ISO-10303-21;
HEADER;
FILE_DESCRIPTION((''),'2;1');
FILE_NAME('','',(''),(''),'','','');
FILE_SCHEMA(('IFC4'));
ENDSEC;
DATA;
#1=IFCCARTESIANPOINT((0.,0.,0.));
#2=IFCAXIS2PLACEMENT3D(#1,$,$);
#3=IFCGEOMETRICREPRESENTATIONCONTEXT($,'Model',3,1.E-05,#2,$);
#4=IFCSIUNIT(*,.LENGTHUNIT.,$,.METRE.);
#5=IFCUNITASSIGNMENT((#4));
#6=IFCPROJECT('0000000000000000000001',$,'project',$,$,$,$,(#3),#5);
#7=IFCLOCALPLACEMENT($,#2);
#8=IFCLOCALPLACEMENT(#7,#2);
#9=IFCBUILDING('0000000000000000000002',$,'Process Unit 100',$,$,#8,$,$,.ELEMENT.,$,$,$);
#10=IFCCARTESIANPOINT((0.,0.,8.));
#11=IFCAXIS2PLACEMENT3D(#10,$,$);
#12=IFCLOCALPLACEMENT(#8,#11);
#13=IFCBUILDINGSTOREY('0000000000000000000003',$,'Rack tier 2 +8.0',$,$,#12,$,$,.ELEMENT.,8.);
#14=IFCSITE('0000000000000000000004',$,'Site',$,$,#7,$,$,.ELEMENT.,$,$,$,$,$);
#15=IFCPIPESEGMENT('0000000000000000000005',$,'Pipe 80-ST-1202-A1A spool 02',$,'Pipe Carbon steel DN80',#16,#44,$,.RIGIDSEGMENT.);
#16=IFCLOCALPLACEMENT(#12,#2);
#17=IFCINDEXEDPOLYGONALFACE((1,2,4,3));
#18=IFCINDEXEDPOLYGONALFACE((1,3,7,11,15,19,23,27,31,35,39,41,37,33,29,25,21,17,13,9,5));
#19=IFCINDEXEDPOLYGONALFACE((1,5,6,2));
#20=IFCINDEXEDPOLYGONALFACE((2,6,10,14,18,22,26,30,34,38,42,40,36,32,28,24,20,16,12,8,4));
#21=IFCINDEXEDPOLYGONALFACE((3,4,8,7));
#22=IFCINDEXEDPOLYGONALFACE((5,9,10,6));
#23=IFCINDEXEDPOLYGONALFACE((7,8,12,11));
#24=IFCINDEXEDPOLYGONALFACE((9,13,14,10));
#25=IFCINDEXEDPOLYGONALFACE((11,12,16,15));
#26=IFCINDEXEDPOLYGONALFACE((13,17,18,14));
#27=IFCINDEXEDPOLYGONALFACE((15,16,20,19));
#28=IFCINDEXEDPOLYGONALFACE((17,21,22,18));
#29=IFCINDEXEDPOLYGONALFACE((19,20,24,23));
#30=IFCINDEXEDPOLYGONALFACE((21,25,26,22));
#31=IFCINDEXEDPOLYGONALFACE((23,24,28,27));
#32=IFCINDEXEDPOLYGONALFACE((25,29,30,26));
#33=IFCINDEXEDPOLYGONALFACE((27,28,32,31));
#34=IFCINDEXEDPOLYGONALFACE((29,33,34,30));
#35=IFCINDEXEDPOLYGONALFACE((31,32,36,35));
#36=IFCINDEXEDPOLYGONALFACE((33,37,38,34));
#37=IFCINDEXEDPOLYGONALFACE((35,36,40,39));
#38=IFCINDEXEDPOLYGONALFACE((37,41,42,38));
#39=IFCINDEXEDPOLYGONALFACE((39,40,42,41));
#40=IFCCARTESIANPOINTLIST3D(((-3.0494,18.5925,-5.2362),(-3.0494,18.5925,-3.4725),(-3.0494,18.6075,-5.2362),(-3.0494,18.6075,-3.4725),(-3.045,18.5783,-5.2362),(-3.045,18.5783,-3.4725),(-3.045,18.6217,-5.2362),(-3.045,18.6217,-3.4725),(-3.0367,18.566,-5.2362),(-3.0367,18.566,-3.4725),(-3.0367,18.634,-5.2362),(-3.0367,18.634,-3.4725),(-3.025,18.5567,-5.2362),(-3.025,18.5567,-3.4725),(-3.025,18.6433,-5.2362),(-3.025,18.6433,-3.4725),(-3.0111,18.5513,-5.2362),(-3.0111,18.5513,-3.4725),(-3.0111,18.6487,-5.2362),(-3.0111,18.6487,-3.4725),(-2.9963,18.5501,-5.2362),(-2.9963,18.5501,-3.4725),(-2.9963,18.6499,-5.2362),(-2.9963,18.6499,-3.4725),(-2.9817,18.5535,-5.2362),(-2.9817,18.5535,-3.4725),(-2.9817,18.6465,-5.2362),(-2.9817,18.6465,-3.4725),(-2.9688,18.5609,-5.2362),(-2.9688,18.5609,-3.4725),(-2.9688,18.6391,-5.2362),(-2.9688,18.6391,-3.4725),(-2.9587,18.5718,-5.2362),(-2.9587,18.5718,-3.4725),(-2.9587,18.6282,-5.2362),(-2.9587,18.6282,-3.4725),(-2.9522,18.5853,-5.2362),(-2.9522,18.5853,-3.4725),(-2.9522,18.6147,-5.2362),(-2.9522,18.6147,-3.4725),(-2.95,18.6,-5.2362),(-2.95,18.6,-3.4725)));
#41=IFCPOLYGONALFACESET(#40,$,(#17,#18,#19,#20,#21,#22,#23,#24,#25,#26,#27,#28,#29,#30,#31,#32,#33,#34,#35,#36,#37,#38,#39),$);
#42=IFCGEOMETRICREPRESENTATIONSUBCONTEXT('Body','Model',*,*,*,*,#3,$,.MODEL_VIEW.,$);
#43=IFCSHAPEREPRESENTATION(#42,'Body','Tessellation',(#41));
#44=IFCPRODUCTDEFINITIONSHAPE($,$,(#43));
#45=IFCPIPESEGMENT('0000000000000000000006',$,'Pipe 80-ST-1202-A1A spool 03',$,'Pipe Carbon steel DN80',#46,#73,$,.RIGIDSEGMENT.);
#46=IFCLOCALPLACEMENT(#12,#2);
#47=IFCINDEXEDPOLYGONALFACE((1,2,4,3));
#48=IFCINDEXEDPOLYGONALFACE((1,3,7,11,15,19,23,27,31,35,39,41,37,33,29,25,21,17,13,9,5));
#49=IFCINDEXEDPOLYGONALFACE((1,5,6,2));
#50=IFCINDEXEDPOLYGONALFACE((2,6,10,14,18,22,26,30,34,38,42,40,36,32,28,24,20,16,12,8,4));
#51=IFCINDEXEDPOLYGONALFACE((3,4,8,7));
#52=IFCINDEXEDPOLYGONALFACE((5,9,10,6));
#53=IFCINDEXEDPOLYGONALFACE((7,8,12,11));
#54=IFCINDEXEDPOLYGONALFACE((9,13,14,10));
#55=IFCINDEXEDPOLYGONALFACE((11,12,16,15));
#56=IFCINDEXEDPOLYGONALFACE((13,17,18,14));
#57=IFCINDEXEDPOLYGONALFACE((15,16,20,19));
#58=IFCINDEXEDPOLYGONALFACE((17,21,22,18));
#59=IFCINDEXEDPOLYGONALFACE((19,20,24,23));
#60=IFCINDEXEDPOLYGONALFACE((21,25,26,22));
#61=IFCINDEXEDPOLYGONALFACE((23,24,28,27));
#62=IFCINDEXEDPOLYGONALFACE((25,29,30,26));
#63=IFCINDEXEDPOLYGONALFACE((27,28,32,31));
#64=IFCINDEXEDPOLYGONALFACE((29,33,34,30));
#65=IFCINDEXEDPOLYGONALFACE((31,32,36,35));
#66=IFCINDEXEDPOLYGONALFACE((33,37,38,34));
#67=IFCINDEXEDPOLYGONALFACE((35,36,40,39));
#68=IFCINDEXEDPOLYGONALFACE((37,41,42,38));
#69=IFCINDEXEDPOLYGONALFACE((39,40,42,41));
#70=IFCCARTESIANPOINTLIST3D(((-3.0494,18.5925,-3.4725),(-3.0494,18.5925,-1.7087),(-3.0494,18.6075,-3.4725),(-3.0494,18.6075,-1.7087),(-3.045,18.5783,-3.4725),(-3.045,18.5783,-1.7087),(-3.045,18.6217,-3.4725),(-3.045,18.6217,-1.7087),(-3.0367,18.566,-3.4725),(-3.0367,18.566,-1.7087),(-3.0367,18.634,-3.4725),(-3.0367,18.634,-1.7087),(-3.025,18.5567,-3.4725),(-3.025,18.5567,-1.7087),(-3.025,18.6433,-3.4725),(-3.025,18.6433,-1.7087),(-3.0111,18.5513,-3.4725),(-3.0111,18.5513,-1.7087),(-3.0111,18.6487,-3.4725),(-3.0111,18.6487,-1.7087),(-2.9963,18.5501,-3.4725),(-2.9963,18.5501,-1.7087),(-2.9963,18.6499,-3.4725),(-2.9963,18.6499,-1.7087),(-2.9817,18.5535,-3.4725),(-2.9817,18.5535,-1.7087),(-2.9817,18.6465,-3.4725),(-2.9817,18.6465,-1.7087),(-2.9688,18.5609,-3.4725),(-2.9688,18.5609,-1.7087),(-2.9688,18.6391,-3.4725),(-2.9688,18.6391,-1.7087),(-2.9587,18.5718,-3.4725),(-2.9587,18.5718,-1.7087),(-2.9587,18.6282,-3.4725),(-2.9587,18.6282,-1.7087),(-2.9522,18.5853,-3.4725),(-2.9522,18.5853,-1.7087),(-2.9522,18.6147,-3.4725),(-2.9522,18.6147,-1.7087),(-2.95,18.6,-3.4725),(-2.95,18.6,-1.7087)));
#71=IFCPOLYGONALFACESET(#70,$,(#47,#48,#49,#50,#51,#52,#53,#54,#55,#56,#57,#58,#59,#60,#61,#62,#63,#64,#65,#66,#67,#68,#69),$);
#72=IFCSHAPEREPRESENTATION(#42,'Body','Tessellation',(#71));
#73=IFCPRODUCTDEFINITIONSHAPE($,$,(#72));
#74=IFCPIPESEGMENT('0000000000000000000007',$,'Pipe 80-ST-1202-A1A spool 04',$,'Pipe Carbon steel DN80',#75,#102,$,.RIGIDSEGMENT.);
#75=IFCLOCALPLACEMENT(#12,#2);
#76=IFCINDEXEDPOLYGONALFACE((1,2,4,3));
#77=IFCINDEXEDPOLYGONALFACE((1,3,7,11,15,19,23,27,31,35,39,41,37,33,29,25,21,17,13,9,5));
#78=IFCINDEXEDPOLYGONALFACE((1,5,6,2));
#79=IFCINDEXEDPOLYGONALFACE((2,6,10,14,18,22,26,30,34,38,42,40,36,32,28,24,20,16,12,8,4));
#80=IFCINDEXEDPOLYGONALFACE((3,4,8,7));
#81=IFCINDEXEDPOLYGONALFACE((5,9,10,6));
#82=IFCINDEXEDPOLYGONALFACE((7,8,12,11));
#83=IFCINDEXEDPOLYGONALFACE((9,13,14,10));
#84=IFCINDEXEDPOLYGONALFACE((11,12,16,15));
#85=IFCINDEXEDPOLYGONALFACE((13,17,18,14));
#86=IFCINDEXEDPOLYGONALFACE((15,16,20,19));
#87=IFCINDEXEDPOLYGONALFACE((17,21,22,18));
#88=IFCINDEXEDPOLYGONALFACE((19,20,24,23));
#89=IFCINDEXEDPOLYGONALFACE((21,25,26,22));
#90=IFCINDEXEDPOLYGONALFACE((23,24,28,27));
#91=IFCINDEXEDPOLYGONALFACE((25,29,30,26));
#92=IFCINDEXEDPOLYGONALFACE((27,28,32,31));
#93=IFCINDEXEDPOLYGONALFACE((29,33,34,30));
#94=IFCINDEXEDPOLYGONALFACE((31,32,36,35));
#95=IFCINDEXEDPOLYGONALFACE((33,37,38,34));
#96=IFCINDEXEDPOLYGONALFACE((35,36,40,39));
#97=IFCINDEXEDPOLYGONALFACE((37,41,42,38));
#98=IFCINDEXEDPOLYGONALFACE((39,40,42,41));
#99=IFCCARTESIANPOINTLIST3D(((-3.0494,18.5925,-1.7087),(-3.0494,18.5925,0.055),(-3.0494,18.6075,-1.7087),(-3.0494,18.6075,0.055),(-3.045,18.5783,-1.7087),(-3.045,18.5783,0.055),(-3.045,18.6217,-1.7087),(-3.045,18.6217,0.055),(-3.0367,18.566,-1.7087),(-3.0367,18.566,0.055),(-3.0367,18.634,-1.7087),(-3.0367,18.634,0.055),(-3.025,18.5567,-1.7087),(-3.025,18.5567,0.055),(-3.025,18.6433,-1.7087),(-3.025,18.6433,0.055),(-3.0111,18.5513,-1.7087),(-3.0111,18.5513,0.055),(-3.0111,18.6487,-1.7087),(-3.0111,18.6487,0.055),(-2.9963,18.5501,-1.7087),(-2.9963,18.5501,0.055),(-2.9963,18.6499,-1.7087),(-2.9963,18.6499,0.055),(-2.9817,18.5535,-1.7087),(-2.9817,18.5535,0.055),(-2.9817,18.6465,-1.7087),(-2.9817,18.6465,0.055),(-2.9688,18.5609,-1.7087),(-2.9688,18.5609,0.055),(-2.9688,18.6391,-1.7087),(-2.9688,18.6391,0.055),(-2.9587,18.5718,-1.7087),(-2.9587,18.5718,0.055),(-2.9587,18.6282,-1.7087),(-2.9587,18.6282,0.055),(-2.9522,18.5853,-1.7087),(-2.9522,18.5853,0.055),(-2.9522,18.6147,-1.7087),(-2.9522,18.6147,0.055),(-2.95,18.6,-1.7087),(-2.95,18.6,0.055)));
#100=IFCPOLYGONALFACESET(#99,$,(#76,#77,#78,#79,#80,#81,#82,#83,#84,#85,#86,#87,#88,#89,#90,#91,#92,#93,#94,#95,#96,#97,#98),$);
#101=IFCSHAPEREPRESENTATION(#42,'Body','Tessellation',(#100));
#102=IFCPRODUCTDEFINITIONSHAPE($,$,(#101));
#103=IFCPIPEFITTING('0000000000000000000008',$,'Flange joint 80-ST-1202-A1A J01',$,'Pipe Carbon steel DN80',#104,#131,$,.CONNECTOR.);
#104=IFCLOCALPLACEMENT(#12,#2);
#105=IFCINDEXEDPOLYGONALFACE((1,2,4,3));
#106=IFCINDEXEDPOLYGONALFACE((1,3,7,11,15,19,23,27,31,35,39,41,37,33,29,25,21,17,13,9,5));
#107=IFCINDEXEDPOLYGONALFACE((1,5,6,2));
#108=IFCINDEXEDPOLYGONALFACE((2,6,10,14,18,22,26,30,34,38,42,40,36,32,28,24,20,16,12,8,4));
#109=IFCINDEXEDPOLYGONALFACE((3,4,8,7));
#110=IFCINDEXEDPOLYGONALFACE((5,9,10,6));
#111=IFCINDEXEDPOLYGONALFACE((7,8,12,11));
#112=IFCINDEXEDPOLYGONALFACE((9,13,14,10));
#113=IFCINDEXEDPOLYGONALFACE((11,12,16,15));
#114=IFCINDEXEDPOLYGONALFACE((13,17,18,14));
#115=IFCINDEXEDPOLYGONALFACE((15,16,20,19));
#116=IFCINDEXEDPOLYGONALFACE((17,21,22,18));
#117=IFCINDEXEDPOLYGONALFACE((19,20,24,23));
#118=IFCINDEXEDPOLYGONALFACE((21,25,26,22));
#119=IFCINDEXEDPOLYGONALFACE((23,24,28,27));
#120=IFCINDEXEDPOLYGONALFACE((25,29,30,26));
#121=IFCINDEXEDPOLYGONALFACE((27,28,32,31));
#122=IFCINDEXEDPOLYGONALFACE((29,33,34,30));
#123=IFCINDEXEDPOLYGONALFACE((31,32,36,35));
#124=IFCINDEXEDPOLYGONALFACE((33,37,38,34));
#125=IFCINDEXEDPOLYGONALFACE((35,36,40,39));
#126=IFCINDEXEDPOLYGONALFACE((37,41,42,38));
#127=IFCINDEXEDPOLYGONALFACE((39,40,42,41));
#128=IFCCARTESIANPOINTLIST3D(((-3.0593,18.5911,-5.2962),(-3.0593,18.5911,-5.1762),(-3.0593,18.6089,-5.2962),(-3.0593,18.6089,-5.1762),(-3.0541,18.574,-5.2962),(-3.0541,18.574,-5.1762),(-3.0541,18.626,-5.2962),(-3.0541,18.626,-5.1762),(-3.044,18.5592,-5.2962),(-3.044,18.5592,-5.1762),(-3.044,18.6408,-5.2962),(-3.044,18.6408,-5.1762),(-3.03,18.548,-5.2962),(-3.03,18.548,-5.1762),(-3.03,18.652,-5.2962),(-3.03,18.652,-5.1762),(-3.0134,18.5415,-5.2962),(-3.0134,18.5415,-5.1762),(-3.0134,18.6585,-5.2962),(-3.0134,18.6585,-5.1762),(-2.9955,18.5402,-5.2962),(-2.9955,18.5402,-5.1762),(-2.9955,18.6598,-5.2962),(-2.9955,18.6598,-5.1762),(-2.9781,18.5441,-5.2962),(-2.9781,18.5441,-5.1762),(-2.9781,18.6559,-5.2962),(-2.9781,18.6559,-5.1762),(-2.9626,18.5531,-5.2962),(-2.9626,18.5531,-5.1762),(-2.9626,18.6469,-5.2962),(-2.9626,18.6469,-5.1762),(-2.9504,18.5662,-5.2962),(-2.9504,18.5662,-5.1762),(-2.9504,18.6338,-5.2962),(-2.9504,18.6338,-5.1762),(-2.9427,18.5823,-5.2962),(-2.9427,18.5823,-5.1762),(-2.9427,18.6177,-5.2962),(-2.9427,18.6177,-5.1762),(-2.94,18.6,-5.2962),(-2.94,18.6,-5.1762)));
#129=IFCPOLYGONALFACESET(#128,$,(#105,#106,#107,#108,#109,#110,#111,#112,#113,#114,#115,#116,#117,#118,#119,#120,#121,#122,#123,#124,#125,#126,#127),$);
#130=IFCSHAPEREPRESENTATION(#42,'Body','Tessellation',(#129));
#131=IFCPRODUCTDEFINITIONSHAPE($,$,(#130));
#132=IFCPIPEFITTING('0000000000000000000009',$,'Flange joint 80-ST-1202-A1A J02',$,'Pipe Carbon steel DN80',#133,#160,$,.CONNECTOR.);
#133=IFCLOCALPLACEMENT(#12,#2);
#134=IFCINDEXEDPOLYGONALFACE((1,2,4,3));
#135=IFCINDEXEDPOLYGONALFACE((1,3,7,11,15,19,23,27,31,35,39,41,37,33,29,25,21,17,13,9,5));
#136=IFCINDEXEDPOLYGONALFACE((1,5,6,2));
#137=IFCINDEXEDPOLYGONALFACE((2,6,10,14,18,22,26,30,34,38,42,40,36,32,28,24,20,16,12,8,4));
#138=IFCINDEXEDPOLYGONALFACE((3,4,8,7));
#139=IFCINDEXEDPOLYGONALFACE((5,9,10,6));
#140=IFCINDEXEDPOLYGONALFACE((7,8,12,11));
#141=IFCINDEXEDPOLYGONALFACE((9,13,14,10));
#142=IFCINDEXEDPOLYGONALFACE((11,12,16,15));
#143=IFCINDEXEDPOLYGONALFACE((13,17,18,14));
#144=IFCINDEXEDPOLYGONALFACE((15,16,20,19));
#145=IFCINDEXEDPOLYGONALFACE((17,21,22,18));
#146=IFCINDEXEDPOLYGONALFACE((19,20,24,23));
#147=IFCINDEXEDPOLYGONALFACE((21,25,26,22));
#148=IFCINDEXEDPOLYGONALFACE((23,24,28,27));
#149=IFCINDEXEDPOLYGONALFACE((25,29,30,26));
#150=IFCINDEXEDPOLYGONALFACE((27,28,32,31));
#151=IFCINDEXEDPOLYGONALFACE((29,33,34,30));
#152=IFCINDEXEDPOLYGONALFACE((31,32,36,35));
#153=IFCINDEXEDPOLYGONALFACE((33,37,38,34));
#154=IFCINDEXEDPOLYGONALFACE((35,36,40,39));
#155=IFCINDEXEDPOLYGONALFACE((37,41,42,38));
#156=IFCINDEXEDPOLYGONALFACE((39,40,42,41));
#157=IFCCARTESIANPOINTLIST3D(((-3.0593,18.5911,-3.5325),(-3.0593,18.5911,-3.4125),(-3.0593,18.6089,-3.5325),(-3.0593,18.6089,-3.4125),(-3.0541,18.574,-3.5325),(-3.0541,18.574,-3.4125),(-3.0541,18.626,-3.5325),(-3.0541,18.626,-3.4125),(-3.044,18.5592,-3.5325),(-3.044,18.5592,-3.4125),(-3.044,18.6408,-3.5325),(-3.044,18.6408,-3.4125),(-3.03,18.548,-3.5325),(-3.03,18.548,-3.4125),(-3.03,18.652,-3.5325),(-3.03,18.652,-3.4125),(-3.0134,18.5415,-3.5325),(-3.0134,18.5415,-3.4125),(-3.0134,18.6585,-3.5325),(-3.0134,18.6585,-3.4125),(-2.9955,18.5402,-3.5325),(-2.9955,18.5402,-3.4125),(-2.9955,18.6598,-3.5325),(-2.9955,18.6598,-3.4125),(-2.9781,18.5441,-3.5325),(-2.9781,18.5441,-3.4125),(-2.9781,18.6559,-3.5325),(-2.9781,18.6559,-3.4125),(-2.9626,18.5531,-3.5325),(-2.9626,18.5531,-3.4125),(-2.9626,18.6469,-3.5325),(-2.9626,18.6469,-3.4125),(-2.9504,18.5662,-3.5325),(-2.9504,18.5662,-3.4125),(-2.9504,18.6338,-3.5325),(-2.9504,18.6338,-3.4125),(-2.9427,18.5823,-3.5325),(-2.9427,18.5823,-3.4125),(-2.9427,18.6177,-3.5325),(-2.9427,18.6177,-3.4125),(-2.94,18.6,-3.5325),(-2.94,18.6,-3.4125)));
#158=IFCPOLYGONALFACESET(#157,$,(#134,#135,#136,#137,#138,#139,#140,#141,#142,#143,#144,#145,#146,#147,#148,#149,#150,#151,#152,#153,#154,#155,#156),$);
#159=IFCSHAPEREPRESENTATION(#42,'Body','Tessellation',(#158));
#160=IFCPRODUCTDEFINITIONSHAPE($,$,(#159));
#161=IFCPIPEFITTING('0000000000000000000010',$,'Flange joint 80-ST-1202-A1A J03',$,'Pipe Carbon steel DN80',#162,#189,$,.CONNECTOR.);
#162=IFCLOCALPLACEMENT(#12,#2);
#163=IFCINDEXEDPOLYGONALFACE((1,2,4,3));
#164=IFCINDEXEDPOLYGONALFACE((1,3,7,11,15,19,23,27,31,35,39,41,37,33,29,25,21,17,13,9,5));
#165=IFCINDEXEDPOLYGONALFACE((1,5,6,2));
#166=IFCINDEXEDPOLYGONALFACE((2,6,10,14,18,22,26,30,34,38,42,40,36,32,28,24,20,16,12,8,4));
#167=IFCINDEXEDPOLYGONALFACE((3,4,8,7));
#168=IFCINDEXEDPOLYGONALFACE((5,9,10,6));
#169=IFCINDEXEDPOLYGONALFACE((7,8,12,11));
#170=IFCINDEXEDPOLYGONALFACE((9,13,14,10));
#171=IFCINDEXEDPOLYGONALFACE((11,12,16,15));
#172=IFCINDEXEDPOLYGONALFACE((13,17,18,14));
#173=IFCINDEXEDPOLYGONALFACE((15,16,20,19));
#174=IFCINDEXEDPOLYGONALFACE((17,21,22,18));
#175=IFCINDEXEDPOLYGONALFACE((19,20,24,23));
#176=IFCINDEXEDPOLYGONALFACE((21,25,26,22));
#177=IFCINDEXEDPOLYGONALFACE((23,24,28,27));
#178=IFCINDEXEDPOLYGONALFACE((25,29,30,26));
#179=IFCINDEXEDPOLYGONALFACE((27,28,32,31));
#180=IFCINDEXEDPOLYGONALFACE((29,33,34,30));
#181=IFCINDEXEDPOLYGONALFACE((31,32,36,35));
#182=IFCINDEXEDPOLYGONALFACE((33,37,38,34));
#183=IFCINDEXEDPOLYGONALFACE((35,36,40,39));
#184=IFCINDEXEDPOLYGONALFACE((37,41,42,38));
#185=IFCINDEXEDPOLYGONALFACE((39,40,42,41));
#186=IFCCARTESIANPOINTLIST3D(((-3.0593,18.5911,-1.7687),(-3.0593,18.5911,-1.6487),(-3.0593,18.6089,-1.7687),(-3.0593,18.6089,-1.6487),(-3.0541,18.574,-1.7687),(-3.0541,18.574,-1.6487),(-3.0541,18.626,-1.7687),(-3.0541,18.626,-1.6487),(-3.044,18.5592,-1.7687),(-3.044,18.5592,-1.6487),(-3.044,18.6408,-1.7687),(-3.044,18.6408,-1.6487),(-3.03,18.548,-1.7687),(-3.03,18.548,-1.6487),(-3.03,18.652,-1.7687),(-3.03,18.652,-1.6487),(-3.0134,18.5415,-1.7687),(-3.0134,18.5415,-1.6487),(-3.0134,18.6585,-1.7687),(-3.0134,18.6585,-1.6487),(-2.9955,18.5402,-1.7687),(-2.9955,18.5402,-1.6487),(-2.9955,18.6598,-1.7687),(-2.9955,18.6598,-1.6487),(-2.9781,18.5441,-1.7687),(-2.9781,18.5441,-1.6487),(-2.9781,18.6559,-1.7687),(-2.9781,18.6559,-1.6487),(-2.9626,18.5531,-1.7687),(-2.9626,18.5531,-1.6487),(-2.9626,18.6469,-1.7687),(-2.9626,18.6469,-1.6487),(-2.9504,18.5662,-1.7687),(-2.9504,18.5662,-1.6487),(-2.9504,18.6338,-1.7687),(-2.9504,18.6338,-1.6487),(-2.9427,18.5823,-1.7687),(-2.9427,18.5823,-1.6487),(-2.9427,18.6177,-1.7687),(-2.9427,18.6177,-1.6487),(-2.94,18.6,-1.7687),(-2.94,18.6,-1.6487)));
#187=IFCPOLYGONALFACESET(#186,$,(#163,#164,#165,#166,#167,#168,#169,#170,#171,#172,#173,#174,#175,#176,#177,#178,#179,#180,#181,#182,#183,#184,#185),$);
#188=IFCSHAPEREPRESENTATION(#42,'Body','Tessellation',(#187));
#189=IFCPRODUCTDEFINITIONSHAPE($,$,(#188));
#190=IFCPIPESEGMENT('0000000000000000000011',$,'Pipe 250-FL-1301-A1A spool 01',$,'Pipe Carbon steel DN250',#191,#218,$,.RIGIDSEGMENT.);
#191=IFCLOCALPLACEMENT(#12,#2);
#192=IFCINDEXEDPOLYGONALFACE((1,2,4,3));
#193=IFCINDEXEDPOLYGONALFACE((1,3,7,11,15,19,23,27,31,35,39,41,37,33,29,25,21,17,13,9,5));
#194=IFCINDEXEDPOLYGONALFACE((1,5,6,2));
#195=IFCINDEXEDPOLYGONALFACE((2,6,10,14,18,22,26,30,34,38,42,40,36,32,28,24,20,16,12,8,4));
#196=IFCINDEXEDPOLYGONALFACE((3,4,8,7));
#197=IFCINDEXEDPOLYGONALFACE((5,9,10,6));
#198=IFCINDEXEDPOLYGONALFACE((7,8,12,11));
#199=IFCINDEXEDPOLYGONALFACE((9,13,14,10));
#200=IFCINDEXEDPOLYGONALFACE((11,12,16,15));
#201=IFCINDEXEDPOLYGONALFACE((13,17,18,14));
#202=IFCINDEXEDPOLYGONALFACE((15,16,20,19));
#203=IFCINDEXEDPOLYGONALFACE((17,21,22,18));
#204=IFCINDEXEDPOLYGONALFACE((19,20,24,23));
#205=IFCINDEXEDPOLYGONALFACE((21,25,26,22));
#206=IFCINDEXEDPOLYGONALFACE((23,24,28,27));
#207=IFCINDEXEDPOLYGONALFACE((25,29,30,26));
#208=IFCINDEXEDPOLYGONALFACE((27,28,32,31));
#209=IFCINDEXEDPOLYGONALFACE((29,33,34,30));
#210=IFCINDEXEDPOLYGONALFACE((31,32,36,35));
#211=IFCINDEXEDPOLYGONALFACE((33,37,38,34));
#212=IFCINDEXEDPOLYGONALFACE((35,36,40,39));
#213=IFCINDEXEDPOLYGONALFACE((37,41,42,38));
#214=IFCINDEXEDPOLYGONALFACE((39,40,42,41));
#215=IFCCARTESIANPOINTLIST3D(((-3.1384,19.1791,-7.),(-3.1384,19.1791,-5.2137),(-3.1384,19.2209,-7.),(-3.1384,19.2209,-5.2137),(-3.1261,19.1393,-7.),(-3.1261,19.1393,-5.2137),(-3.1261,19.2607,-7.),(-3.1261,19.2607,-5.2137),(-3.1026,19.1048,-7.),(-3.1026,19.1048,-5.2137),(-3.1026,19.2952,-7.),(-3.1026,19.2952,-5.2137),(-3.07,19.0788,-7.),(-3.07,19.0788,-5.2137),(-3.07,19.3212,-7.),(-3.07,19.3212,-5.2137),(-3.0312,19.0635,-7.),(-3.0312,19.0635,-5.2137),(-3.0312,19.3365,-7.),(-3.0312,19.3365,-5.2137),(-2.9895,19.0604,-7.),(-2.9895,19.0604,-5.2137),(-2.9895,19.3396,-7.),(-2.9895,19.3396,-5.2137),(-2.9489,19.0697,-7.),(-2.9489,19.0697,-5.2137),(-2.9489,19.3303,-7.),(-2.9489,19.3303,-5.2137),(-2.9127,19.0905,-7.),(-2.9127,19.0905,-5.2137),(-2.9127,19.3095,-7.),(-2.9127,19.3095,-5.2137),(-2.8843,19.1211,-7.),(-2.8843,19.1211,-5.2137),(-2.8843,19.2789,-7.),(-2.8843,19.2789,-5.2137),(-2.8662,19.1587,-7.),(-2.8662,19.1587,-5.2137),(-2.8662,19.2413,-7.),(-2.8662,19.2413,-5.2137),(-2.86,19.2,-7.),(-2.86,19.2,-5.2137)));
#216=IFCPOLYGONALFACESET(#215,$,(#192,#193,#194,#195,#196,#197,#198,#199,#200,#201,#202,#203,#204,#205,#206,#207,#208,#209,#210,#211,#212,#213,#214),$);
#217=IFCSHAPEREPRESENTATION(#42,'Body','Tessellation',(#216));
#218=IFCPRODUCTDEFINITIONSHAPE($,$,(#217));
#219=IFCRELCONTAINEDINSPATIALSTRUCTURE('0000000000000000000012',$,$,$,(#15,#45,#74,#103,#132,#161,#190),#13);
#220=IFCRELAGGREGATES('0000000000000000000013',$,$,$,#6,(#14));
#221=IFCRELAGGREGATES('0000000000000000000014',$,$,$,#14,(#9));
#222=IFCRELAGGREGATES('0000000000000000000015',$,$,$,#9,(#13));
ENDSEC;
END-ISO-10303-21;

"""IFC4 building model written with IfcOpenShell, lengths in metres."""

from ifc_helpers import new_model, si_unit, frame, origin, place, context, subcontext, project, spatial, circle, extrude, element, save


model = new_model("IFC4")

# Units and contexts
model_context = context("Model", 3, precision=1e-05, world=origin())
body_context = subcontext(model_context, "Body", "Model", "MODEL_VIEW")
ifc_project = project(units=[si_unit("LENGTHUNIT", "METRE")], contexts=[model_context])

# Site, building, storey
site_placement = place(None, origin())
site = spatial("IfcSite", under=ifc_project, at=site_placement, Name="Site", CompositionType="ELEMENT")
building_placement = place(site_placement, origin())
building = spatial("IfcBuilding", under=site, at=building_placement, Name="Process Unit 100", CompositionType="ELEMENT")
storey_placement = place(building_placement, frame((0.0, 0.0, 8.0)))
storey = spatial("IfcBuildingStorey", under=building, at=storey_placement, Name="Rack tier 2 +8.0", CompositionType="ELEMENT", Elevation=8.0)

# Pipe segments
for number, where, z_axis, x_axis, name in (
    (1, (-3.0, 18.6, -5.2363), (0.0, 0.0, 1.0), (1.0, 0.0, 0.0), "Pipe 80-ST-1202-A1A spool 02"),
    (2, (-3.0, 18.6, -3.4725), (0.0, 0.0, 1.0), (1.0, 0.0, 0.0), "Pipe 80-ST-1202-A1A spool 03"),
    (3, (-3.0, 18.6, -1.7087), (0.0, 0.0, 1.0), (1.0, 0.0, 0.0), "Pipe 80-ST-1202-A1A spool 04"),
):
    element("IfcPipeSegment", number, at=place(storey_placement, frame(where, z_axis=z_axis, x_axis=x_axis)), inside=storey, Name=name, ObjectType="Pipe Carbon steel DN80", PredefinedType="RIGIDSEGMENT", context=body_context, shape_type="SweptSolid", body=[
        extrude(circle(Radius=0.05), origin(), (0.0, 0.0, 1.0), 1.7638),
    ])

# Pipe fittings
for number, where, z_axis, x_axis, name in (
    (4, (-3.0, 18.6, -5.2962), (0.0, 0.0, 1.0), (1.0, 0.0, 0.0), "Flange joint 80-ST-1202-A1A J01"),
    (5, (-3.0, 18.6, -3.5325), (0.0, 0.0, 1.0), (1.0, 0.0, 0.0), "Flange joint 80-ST-1202-A1A J02"),
    (6, (-3.0, 18.6, -1.7687), (0.0, 0.0, 1.0), (1.0, 0.0, 0.0), "Flange joint 80-ST-1202-A1A J03"),
):
    element("IfcPipeFitting", number, at=place(storey_placement, frame(where, z_axis=z_axis, x_axis=x_axis)), inside=storey, Name=name, ObjectType="Pipe Carbon steel DN80", PredefinedType="CONNECTOR", context=body_context, shape_type="SweptSolid", body=[
        extrude(circle(Radius=0.06), origin(), (0.0, 0.0, 1.0), 0.12),
    ])

# Pipe segment
for number, where, z_axis, x_axis, name in (
    (7, (-3.0, 19.2, -7.0), (0.0, 0.0, 1.0), (1.0, 0.0, 0.0), "Pipe 250-FL-1301-A1A spool 01"),
):
    element("IfcPipeSegment", number, at=place(storey_placement, frame(where, z_axis=z_axis, x_axis=x_axis)), inside=storey, Name=name, ObjectType="Pipe Carbon steel DN250", PredefinedType="RIGIDSEGMENT", context=body_context, shape_type="SweptSolid", body=[
        extrude(circle(Radius=0.14), origin(), (0.0, 0.0, 1.0), 1.7863),
    ])

save(model, "model.ifc")
